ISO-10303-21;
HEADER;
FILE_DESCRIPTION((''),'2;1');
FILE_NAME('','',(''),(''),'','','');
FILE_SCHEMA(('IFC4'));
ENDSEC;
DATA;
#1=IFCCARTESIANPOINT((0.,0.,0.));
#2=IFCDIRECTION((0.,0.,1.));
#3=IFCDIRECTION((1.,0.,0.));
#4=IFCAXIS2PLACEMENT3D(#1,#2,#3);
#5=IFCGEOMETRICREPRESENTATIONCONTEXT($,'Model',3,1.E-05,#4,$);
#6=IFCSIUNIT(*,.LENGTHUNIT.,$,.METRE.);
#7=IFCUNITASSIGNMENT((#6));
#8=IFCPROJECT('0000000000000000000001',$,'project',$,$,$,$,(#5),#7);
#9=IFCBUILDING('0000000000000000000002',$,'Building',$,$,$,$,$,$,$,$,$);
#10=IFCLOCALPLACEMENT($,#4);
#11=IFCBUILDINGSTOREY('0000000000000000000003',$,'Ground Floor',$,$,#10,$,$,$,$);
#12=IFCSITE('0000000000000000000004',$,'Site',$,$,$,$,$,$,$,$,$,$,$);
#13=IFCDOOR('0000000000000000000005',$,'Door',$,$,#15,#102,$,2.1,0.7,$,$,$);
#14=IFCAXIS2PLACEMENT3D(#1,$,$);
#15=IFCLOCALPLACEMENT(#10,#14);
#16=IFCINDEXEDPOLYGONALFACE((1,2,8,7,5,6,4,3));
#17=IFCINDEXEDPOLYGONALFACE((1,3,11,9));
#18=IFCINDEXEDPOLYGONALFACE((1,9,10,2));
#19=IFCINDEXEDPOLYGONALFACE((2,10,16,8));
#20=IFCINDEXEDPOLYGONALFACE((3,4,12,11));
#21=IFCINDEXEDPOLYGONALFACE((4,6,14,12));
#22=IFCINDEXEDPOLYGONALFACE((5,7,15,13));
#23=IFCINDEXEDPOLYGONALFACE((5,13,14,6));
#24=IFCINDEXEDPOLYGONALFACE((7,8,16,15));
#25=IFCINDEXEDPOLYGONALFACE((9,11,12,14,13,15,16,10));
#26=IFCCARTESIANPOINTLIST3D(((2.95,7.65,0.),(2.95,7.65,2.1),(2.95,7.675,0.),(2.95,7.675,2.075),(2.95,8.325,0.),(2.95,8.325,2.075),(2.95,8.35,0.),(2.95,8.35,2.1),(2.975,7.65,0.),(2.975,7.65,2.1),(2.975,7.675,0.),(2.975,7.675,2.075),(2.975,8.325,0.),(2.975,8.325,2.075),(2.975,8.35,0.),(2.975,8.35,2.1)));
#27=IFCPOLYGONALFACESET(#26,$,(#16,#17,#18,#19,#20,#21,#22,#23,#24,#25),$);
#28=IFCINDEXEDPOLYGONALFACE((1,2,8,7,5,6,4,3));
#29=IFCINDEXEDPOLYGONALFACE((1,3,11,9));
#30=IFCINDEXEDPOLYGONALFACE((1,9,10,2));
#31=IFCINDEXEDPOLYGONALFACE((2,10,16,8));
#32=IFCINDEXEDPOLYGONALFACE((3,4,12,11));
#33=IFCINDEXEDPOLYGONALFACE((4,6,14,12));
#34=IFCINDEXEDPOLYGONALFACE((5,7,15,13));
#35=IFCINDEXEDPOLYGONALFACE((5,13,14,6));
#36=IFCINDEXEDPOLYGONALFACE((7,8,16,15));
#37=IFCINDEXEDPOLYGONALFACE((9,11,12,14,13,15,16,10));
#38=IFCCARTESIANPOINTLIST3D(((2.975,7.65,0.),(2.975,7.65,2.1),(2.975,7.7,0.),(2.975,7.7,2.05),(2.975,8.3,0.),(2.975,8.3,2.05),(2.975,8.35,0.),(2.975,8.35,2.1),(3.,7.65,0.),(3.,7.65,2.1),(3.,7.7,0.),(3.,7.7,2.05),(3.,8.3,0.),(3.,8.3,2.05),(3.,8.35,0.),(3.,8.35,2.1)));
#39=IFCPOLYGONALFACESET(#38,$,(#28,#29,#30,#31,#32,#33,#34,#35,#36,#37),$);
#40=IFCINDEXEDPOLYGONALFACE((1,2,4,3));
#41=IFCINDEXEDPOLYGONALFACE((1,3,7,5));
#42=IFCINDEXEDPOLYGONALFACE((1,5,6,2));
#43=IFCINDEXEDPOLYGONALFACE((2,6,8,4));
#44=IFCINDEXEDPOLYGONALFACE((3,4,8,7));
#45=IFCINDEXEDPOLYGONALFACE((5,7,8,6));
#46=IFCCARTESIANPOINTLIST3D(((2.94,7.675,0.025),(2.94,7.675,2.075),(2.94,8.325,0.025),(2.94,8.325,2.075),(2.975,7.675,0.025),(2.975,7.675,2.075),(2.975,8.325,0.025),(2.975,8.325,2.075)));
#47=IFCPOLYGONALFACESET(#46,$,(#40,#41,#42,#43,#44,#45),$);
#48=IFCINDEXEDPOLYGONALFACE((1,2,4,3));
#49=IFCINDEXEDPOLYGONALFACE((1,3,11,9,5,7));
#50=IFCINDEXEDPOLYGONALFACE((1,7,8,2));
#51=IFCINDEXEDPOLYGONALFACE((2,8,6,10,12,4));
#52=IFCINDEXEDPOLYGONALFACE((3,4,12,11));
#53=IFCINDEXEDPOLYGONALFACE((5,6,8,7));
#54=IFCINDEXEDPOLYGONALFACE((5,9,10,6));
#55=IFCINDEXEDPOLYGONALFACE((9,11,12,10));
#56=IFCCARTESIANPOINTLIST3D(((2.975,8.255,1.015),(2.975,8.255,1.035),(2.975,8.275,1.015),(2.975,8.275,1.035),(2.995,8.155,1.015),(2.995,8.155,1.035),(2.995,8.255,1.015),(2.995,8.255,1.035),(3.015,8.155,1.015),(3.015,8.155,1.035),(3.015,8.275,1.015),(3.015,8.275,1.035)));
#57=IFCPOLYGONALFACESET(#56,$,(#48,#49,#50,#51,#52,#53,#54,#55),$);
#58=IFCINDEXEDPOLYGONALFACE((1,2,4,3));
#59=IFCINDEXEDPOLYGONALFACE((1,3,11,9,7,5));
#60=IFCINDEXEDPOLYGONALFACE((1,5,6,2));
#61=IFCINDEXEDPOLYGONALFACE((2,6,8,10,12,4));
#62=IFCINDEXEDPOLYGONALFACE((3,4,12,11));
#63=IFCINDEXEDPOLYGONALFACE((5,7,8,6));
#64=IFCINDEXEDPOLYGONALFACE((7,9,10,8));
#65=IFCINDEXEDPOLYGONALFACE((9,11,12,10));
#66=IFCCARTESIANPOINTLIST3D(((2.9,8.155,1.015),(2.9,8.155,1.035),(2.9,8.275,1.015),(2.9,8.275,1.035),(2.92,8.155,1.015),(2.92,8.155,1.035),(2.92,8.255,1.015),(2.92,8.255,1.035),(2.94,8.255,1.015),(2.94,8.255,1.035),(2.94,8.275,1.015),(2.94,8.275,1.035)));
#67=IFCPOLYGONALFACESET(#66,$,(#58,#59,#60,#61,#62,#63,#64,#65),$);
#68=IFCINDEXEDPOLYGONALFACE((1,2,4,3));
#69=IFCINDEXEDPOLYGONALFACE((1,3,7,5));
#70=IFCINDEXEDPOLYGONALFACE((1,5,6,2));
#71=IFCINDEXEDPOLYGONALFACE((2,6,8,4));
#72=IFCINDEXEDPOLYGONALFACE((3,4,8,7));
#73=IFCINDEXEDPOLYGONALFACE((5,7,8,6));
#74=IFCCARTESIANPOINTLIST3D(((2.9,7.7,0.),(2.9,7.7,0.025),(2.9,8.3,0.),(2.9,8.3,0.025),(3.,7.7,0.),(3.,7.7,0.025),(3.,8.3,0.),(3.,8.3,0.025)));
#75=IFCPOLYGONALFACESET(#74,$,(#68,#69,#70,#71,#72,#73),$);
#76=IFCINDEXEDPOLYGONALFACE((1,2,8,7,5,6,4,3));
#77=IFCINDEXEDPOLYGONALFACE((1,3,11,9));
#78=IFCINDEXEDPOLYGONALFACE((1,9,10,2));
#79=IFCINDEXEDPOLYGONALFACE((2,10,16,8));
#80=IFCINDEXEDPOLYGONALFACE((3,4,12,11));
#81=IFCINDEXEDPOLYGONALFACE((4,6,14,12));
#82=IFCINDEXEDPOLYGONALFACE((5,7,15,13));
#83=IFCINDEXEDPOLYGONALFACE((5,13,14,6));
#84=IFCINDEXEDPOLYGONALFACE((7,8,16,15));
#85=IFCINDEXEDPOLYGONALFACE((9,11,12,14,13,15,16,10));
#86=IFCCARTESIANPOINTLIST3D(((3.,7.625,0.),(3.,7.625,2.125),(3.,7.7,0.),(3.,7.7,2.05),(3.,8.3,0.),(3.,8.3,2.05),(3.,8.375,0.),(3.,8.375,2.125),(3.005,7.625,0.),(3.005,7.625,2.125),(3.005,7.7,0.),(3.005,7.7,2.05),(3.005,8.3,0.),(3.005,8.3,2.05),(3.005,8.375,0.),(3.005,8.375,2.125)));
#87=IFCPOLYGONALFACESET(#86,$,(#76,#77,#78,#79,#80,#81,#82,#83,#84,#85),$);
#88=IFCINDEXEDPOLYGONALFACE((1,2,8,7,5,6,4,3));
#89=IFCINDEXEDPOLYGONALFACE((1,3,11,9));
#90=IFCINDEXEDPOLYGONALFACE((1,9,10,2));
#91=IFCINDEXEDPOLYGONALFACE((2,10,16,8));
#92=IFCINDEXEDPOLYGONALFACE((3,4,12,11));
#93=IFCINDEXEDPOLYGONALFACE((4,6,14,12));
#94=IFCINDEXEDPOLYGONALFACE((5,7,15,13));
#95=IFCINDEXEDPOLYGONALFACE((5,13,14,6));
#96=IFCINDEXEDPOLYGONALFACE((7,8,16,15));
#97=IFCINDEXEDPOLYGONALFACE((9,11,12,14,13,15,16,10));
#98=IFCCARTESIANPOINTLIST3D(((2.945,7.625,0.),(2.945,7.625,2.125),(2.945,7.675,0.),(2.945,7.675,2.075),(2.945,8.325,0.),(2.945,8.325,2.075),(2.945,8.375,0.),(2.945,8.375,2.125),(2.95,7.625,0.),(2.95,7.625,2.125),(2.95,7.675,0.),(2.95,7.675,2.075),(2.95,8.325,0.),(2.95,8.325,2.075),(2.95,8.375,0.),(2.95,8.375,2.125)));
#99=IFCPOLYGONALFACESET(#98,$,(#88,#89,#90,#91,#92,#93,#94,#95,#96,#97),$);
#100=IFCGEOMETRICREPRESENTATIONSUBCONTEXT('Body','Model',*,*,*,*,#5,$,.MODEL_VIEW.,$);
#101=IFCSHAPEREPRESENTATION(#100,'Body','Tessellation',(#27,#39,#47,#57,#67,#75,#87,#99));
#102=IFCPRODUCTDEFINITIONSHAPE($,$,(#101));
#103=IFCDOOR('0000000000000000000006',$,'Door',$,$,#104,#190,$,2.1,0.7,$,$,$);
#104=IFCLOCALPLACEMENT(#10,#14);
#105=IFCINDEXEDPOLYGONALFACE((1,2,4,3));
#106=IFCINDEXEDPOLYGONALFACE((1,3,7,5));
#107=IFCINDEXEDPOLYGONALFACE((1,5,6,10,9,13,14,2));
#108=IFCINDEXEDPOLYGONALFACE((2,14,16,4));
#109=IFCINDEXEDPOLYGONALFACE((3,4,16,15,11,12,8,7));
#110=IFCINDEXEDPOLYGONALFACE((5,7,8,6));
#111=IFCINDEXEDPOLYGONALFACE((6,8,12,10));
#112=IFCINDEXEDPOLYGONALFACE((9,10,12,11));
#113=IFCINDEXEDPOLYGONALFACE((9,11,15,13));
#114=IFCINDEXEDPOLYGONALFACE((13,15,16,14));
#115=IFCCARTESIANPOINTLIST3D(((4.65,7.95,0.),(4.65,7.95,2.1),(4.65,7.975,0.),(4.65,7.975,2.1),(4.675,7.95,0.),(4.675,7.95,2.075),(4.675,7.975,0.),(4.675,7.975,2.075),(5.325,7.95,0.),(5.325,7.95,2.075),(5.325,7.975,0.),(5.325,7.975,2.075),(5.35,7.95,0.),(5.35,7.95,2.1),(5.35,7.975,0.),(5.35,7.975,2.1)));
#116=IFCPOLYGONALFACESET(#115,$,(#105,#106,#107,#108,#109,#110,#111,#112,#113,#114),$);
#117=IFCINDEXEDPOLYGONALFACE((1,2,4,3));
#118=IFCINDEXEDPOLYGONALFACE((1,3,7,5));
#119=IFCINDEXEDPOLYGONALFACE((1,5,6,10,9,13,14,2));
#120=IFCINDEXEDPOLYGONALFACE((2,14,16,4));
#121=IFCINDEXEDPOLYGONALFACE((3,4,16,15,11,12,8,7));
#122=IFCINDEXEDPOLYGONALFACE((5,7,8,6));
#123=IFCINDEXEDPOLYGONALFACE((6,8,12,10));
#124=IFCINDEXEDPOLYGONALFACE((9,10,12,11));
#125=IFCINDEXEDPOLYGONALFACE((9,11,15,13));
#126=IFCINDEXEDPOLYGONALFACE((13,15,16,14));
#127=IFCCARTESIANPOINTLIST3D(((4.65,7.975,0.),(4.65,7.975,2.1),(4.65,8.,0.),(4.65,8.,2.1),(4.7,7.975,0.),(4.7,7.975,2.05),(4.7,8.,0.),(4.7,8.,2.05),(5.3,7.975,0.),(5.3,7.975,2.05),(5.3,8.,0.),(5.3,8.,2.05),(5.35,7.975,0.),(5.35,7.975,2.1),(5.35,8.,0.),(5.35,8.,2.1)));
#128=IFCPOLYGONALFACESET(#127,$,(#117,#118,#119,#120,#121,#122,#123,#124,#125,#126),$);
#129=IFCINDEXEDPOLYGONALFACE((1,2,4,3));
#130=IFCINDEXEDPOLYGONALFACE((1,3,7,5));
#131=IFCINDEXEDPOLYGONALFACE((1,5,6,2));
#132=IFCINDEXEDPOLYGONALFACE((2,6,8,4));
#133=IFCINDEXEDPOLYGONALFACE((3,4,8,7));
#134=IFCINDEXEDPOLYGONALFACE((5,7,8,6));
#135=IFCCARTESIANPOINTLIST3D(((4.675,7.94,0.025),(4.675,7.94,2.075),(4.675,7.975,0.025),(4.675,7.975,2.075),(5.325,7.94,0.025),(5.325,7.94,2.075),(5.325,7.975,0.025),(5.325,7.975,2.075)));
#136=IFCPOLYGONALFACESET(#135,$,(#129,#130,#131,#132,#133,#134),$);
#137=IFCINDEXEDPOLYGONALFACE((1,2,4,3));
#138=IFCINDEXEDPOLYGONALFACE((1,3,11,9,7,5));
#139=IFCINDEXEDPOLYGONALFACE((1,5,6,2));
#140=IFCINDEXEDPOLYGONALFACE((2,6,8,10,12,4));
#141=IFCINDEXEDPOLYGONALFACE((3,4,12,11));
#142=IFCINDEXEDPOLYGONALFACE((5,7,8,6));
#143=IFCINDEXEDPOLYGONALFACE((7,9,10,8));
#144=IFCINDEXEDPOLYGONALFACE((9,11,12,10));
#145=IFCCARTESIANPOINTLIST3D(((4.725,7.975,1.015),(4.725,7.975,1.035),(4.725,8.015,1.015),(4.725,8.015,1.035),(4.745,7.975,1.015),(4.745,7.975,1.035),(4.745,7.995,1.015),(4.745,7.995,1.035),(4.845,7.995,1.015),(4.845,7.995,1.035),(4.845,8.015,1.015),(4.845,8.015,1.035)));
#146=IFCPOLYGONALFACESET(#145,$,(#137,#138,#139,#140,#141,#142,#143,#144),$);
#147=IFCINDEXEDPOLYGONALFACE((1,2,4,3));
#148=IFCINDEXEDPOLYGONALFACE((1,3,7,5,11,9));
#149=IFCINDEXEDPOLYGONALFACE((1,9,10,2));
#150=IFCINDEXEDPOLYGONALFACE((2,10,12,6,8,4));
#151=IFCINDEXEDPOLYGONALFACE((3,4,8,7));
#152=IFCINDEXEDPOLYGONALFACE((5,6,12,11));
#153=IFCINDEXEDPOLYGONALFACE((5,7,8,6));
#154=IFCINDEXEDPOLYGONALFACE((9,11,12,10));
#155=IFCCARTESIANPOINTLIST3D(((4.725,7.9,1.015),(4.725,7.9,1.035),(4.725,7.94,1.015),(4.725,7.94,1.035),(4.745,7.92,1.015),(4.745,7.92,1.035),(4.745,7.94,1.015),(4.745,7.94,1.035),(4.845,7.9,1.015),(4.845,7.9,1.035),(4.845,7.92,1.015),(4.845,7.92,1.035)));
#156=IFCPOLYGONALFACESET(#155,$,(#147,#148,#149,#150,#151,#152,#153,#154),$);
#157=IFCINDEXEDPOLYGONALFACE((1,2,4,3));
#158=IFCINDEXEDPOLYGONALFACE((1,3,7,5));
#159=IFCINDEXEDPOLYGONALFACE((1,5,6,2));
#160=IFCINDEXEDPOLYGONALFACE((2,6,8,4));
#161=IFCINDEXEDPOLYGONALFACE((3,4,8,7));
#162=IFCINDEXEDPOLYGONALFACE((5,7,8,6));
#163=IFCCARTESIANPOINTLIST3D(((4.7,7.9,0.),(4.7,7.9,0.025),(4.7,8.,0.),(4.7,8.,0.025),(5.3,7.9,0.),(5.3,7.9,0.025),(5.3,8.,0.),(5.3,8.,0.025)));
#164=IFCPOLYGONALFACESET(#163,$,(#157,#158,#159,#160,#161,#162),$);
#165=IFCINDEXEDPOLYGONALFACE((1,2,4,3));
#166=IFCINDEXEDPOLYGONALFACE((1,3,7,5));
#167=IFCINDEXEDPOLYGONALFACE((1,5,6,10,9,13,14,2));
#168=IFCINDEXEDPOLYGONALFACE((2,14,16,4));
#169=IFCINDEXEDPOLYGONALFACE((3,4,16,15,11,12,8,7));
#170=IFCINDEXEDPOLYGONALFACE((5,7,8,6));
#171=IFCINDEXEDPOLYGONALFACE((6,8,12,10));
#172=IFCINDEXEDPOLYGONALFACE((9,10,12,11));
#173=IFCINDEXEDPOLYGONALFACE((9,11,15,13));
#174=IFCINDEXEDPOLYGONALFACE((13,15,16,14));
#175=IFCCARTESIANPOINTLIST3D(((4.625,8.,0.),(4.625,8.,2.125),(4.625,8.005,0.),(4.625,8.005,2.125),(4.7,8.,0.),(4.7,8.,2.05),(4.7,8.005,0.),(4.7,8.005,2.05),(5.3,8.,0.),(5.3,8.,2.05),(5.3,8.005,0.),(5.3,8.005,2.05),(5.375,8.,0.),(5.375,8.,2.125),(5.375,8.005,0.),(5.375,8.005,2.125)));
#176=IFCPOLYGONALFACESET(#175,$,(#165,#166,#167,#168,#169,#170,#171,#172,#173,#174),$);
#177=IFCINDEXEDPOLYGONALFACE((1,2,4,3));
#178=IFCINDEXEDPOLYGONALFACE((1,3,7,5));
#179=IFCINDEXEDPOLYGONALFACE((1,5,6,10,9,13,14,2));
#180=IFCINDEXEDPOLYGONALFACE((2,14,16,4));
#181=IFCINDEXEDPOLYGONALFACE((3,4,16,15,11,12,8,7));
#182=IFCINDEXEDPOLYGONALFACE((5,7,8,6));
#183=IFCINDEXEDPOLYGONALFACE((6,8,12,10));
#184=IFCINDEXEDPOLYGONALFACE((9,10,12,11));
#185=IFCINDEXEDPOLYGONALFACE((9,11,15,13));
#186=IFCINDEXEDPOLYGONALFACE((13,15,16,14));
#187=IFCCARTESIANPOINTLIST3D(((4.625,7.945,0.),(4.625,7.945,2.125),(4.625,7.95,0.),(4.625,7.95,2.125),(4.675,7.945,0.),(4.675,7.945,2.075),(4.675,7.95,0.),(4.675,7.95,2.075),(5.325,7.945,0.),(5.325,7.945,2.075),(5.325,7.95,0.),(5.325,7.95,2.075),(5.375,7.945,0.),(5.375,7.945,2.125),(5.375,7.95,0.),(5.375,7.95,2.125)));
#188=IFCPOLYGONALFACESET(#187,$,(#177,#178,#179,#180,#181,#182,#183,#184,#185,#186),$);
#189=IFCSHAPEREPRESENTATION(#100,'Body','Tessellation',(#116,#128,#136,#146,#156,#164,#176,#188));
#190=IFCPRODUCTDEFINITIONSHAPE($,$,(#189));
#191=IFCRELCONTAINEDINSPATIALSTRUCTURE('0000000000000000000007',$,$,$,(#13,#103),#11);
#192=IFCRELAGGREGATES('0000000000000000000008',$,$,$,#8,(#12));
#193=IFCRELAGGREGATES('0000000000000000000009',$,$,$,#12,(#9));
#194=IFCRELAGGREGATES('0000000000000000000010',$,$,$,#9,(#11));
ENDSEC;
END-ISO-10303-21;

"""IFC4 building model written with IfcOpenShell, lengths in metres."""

from ifc_helpers import new_model, si_unit, frame, origin_with_axes, place, context, subcontext, project, spatial, line, indexed_curve, outline, extrude, element, save


model = new_model("IFC4")

# Units and contexts
model_context = context("Model", 3, precision=1e-05, world=origin_with_axes())
body_context = subcontext(model_context, "Body", "Model", "MODEL_VIEW")
ifc_project = project(units=[si_unit("LENGTHUNIT", "METRE")], contexts=[model_context])

# Site, building, storey
site = spatial("IfcSite", under=ifc_project, Name="Site")
building = spatial("IfcBuilding", under=site, Name="Building")
storey_placement = place(None, origin_with_axes())
storey = spatial("IfcBuildingStorey", under=building, at=storey_placement, Name="Ground Floor")

# Doors
door_1_placement = place(storey_placement, frame((3.0, 7.65, 0.0), z_axis=(0.0, 0.0, 1.0), x_axis=(0.0, 1.0, 0.0)))
element("IfcDoor", 1, at=door_1_placement, inside=storey, Name="Door", OverallHeight=2.1, OverallWidth=0.7, context=body_context, shape_type="SweptSolid", body=[
    extrude(outline(indexed_curve([(0.0, 0.0), (0.0, 2.1), (0.7, 2.1), (0.7, 0.0), (0.675, 0.0), (0.675, 2.075), (0.025, 2.075), (0.025, 0.0)], segments=[line(1, 2, 3, 4, 5, 6, 7, 8, 1)])), frame((0.0, 0.025, 0.0), z_axis=(0.0, -1.0, 0.0), x_axis=(1.0, 0.0, 0.0)), (0.0, 0.0, -1.0), 0.025),
    extrude(outline(indexed_curve([(0.0, 0.0), (0.0, 2.1), (0.7, 2.1), (0.7, 0.0), (0.65, 0.0), (0.65, 2.05), (0.05, 2.05), (0.05, 0.0)], segments=[line(1, 2, 3, 4, 5, 6, 7, 8, 1)])), frame((0.0, 0.0, 0.0), z_axis=(0.0, -1.0, 0.0), x_axis=(1.0, 0.0, 0.0)), (0.0, 0.0, -1.0), 0.025),
    extrude(outline(indexed_curve([(0.0, 0.0), (0.65, 0.0), (0.65, 0.035), (0.0, 0.035)], segments=[line(1, 2, 3, 4, 1)])), frame((0.025, 0.025, 0.025), z_axis=(0.0, 0.0, 1.0), x_axis=(1.0, 0.0, 0.0)), (0.0, 0.0, 1.0), 2.05),
    extrude(outline(indexed_curve([(0.0, 0.0), (0.0, -0.04), (-0.12, -0.04), (-0.12, -0.02), (-0.02, -0.02), (-0.02, 0.0)], segments=[line(1, 2, 3, 4, 5, 6, 1)])), frame((0.625, 0.025, 1.015), z_axis=(0.0, 0.0, 1.0), x_axis=(1.0, 0.0, 0.0)), (0.0, 0.0, 1.0), 0.02),
    extrude(outline(indexed_curve([(0.0, 0.0), (0.0, 0.04), (-0.12, 0.04), (-0.12, 0.02), (-0.02, 0.02), (-0.02, 0.0)], segments=[line(1, 2, 3, 4, 5, 6, 1)])), frame((0.625, 0.06, 1.015), z_axis=(0.0, 0.0, 1.0), x_axis=(1.0, 0.0, 0.0)), (0.0, 0.0, 1.0), 0.02),
    extrude(outline(indexed_curve([(0.0, 0.0), (0.6, 0.0), (0.6, 0.1), (0.0, 0.1)], segments=[line(1, 2, 3, 4, 1)])), frame((0.05, 0.0, 0.0), z_axis=(0.0, 0.0, 1.0), x_axis=(1.0, 0.0, 0.0)), (0.0, 0.0, 1.0), 0.025),
    extrude(outline(indexed_curve([(0.0, 0.0), (0.0, 2.125), (0.75, 2.125), (0.75, 0.0), (0.675, 0.0), (0.675, 2.05), (0.075, 2.05), (0.075, 0.0)], segments=[line(1, 2, 3, 4, 5, 6, 7, 8, 1)])), frame((-0.025, -0.005, 0.0), z_axis=(0.0, -1.0, 0.0), x_axis=(1.0, 0.0, 0.0)), (0.0, 0.0, -1.0), 0.005),
    extrude(outline(indexed_curve([(0.0, 0.0), (0.0, 2.125), (0.75, 2.125), (0.75, 0.0), (0.7, 0.0), (0.7, 2.075), (0.05, 2.075), (0.05, 0.0)], segments=[line(1, 2, 3, 4, 5, 6, 7, 8, 1)])), frame((-0.025, 0.05, 0.0), z_axis=(0.0, -1.0, 0.0), x_axis=(1.0, 0.0, 0.0)), (0.0, 0.0, -1.0), 0.005),
])
door_2_placement = place(storey_placement, frame((5.35, 8.0, 0.0), z_axis=(0.0, 0.0, 1.0), x_axis=(-1.0, 0.0, 0.0)))
element("IfcDoor", 2, at=door_2_placement, inside=storey, Name="Door", OverallHeight=2.1, OverallWidth=0.7, context=body_context, shape_type="SweptSolid", body=[
    extrude(outline(indexed_curve([(0.0, 0.0), (0.0, 2.1), (0.7, 2.1), (0.7, 0.0), (0.675, 0.0), (0.675, 2.075), (0.025, 2.075), (0.025, 0.0)], segments=[line(1, 2, 3, 4, 5, 6, 7, 8, 1)])), frame((0.0, 0.025, 0.0), z_axis=(0.0, -1.0, 0.0), x_axis=(1.0, 0.0, 0.0)), (0.0, 0.0, -1.0), 0.025),
    extrude(outline(indexed_curve([(0.0, 0.0), (0.0, 2.1), (0.7, 2.1), (0.7, 0.0), (0.65, 0.0), (0.65, 2.05), (0.05, 2.05), (0.05, 0.0)], segments=[line(1, 2, 3, 4, 5, 6, 7, 8, 1)])), frame((0.0, 0.0, 0.0), z_axis=(0.0, -1.0, 0.0), x_axis=(1.0, 0.0, 0.0)), (0.0, 0.0, -1.0), 0.025),
    extrude(outline(indexed_curve([(0.0, 0.0), (0.65, 0.0), (0.65, 0.035), (0.0, 0.035)], segments=[line(1, 2, 3, 4, 1)])), frame((0.025, 0.025, 0.025), z_axis=(0.0, 0.0, 1.0), x_axis=(1.0, 0.0, 0.0)), (0.0, 0.0, 1.0), 2.05),
    extrude(outline(indexed_curve([(0.0, 0.0), (0.0, -0.04), (-0.12, -0.04), (-0.12, -0.02), (-0.02, -0.02), (-0.02, 0.0)], segments=[line(1, 2, 3, 4, 5, 6, 1)])), frame((0.625, 0.025, 1.015), z_axis=(0.0, 0.0, 1.0), x_axis=(1.0, 0.0, 0.0)), (0.0, 0.0, 1.0), 0.02),
    extrude(outline(indexed_curve([(0.0, 0.0), (0.0, 0.04), (-0.12, 0.04), (-0.12, 0.02), (-0.02, 0.02), (-0.02, 0.0)], segments=[line(1, 2, 3, 4, 5, 6, 1)])), frame((0.625, 0.06, 1.015), z_axis=(0.0, 0.0, 1.0), x_axis=(1.0, 0.0, 0.0)), (0.0, 0.0, 1.0), 0.02),
    extrude(outline(indexed_curve([(0.0, 0.0), (0.6, 0.0), (0.6, 0.1), (0.0, 0.1)], segments=[line(1, 2, 3, 4, 1)])), frame((0.05, 0.0, 0.0), z_axis=(0.0, 0.0, 1.0), x_axis=(1.0, 0.0, 0.0)), (0.0, 0.0, 1.0), 0.025),
    extrude(outline(indexed_curve([(0.0, 0.0), (0.0, 2.125), (0.75, 2.125), (0.75, 0.0), (0.675, 0.0), (0.675, 2.05), (0.075, 2.05), (0.075, 0.0)], segments=[line(1, 2, 3, 4, 5, 6, 7, 8, 1)])), frame((-0.025, -0.005, 0.0), z_axis=(0.0, -1.0, 0.0), x_axis=(1.0, 0.0, 0.0)), (0.0, 0.0, -1.0), 0.005),
    extrude(outline(indexed_curve([(0.0, 0.0), (0.0, 2.125), (0.75, 2.125), (0.75, 0.0), (0.7, 0.0), (0.7, 2.075), (0.05, 2.075), (0.05, 0.0)], segments=[line(1, 2, 3, 4, 5, 6, 7, 8, 1)])), frame((-0.025, 0.05, 0.0), z_axis=(0.0, -1.0, 0.0), x_axis=(1.0, 0.0, 0.0)), (0.0, 0.0, -1.0), 0.005),
])

save(model, "model.ifc")
